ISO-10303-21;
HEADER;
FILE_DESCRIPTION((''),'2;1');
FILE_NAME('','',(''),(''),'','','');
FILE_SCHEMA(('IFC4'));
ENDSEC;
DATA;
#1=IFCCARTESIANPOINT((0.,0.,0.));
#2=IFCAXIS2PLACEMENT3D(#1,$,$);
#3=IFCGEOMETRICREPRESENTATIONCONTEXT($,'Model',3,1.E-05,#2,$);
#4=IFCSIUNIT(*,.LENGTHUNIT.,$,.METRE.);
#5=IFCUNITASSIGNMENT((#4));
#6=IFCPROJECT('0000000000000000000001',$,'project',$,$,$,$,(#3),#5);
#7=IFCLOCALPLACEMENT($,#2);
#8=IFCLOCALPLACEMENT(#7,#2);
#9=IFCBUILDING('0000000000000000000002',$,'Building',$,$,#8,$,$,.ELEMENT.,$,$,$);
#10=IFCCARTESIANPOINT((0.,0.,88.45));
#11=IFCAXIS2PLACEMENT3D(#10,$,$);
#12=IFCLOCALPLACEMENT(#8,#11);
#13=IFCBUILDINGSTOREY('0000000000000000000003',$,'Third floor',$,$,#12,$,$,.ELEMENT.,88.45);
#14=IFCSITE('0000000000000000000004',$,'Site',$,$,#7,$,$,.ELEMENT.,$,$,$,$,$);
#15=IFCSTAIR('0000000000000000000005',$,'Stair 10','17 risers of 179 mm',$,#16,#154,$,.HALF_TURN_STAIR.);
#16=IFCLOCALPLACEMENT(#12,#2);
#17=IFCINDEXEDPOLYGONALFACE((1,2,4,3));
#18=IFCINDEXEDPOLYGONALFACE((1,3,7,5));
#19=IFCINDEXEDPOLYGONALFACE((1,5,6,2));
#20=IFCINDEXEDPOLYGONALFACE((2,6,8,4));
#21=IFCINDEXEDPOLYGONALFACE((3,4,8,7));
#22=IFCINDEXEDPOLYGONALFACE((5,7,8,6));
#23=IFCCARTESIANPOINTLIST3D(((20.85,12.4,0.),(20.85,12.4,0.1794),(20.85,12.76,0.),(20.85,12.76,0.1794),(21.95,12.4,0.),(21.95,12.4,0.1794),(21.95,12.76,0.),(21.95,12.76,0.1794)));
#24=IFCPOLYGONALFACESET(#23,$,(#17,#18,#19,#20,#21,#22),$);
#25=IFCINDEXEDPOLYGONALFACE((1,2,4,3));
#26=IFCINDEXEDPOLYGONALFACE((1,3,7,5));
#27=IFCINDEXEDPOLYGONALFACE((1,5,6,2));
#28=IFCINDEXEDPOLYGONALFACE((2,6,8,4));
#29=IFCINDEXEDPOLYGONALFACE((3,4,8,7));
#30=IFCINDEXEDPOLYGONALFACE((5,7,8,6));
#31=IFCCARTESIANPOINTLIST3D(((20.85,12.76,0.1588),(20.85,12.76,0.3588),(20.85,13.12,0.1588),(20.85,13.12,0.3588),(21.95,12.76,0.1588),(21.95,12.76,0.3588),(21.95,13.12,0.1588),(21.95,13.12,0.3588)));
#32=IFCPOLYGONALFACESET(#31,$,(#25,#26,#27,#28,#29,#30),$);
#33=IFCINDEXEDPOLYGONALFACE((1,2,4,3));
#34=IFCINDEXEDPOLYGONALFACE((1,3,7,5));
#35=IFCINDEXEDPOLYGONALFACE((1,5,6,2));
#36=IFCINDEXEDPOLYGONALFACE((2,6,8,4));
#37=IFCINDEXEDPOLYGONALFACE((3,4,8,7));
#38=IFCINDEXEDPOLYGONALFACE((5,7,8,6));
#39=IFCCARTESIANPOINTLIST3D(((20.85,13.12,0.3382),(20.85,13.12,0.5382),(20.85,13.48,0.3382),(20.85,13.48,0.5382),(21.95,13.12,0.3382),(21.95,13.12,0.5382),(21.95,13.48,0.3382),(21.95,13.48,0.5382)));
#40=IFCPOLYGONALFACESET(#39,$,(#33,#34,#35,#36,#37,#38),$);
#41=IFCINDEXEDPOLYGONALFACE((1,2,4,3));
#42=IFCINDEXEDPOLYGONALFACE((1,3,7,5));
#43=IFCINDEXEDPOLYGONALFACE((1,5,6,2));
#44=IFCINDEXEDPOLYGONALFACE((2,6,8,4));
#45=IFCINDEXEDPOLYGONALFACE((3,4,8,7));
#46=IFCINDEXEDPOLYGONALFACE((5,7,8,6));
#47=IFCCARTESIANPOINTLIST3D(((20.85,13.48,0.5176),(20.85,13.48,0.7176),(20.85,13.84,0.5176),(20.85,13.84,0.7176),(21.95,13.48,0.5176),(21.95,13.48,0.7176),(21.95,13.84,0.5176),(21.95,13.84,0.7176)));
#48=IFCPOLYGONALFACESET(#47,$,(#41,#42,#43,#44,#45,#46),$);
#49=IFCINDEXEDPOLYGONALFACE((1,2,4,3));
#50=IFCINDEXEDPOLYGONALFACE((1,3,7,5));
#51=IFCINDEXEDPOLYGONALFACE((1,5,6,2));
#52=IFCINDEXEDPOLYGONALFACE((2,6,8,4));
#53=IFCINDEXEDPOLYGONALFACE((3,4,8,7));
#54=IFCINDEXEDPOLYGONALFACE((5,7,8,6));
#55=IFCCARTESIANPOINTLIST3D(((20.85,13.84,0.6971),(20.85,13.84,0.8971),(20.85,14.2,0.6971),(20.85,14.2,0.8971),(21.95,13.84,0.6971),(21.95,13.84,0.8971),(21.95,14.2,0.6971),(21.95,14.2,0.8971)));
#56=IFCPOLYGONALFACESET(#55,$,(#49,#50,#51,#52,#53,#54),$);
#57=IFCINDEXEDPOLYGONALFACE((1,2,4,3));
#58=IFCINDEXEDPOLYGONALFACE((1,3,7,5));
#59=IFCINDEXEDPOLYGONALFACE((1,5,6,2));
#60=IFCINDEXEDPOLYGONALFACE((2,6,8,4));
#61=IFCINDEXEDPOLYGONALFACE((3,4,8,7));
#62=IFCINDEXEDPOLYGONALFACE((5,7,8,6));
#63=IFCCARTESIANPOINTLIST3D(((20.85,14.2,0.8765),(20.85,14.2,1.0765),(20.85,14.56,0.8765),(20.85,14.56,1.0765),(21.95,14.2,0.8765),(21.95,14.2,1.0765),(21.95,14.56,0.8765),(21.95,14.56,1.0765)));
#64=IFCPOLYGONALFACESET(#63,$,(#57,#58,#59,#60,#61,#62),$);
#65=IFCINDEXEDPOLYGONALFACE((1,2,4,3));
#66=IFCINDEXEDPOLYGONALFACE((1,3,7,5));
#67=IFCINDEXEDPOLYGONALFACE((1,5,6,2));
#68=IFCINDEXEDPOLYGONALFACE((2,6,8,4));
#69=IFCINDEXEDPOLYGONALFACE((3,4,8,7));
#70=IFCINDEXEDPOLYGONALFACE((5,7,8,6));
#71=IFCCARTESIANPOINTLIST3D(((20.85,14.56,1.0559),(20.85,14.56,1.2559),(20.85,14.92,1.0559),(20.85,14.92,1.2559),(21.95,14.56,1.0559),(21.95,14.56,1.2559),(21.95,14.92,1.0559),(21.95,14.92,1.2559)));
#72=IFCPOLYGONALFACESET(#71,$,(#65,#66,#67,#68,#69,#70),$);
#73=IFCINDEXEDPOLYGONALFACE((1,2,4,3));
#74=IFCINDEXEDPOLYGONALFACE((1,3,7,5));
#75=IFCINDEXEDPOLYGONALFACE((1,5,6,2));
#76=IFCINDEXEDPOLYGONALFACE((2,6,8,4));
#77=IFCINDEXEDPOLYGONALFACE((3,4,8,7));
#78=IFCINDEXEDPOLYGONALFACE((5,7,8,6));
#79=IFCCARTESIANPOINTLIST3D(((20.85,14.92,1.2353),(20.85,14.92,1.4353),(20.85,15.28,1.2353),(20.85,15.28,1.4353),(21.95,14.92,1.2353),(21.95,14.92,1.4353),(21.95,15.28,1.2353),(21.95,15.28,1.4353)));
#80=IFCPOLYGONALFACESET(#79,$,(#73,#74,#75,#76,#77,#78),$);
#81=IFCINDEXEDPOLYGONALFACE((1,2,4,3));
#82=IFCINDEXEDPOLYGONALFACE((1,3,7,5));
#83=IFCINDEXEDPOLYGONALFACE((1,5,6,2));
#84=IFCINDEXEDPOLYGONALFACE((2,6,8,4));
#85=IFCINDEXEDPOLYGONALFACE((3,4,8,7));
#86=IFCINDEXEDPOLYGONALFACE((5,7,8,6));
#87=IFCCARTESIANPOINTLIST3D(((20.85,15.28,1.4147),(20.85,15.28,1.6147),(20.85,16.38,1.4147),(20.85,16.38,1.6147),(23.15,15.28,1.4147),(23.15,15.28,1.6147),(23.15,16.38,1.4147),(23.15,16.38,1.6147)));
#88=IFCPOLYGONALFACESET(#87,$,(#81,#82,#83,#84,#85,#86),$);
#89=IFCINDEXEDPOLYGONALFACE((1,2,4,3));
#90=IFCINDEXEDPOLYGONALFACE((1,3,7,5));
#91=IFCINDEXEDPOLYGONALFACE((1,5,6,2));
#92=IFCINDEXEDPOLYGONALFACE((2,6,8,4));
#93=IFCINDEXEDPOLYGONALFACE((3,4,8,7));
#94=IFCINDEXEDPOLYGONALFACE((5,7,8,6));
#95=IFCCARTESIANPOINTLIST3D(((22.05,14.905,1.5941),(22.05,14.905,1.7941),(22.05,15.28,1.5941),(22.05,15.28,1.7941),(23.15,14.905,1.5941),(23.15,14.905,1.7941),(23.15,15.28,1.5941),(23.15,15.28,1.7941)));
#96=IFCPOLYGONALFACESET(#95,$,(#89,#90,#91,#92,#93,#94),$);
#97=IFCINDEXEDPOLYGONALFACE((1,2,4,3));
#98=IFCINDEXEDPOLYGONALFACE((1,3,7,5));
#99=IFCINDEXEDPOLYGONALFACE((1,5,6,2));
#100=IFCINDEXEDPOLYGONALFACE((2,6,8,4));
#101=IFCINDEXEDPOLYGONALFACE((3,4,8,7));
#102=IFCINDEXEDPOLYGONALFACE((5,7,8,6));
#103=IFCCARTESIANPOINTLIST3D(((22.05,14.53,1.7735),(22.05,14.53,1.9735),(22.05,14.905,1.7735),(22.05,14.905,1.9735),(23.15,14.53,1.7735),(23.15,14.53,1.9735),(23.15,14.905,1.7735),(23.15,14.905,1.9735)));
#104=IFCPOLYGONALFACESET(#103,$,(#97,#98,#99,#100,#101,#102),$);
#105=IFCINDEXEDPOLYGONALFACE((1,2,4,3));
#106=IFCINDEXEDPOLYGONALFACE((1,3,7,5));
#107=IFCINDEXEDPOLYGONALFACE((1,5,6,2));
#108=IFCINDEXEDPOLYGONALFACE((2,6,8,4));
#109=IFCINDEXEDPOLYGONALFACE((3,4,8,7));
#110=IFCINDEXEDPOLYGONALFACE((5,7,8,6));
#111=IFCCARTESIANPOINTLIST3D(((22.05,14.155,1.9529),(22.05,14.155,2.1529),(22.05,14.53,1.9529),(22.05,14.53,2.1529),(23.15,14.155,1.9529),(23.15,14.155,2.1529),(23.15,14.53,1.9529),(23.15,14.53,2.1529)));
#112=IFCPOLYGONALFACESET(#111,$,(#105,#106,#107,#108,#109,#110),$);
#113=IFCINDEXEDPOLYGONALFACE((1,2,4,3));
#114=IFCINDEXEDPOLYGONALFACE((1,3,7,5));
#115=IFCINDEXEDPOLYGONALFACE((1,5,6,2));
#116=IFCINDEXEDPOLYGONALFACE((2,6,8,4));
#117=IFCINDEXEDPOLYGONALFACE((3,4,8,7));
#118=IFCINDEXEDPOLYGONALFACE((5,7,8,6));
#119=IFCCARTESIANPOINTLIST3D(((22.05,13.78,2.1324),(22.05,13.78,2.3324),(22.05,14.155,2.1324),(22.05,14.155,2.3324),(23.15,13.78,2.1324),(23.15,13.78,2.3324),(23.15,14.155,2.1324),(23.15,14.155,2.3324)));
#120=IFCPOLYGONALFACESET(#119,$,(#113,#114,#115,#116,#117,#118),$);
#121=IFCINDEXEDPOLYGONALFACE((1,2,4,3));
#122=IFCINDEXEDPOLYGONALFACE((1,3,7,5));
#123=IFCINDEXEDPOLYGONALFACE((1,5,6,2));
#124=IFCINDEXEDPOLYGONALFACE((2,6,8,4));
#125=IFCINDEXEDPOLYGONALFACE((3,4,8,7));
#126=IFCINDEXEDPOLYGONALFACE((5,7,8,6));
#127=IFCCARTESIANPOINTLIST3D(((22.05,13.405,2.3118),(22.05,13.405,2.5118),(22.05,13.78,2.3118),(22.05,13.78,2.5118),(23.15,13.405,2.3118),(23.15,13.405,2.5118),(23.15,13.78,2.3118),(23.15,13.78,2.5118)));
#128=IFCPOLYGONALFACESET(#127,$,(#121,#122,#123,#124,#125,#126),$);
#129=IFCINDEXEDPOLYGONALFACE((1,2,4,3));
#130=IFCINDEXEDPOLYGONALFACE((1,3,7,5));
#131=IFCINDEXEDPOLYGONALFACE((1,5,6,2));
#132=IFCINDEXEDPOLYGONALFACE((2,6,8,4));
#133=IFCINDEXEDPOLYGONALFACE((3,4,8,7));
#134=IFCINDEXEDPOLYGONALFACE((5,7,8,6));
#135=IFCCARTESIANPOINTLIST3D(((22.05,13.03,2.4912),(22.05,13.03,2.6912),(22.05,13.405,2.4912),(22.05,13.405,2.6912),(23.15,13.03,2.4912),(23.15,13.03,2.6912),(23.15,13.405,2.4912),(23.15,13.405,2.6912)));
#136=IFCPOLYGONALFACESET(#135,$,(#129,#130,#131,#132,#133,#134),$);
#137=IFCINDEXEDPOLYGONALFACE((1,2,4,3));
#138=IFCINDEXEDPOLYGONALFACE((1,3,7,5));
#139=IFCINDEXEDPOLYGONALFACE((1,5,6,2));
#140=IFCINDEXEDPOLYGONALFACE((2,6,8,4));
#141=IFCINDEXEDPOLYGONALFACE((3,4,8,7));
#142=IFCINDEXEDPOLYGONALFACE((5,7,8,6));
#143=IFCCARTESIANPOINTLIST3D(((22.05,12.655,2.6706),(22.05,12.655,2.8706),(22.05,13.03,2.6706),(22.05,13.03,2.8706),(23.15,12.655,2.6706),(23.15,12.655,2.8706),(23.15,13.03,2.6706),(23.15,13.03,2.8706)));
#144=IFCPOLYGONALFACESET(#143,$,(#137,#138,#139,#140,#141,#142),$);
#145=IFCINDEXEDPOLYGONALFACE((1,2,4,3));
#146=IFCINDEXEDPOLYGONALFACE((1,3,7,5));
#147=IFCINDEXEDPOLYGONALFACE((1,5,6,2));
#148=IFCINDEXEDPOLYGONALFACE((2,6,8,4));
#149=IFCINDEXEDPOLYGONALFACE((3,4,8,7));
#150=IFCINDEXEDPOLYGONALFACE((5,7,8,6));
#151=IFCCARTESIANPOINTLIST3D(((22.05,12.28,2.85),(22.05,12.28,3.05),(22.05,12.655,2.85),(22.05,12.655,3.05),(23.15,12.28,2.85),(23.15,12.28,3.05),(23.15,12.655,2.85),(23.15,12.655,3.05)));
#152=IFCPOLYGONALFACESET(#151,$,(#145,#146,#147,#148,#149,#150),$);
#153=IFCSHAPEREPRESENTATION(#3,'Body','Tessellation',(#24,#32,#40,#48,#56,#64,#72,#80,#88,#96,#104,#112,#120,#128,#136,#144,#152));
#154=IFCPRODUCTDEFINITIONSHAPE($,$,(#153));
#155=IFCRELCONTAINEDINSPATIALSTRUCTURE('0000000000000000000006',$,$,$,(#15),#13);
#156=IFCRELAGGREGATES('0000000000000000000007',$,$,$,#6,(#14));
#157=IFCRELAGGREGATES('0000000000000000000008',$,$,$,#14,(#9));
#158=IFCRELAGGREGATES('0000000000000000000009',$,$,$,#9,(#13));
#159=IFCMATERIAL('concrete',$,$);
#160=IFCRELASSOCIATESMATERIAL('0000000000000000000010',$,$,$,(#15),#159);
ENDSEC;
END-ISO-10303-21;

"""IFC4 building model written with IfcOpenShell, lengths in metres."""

from ifc_helpers import new_model, si_unit, frame, origin, place, context, project, spatial, polyline, outline, extrude, material, element, save


model = new_model("IFC4")

# Units and contexts
model_context = context("Model", 3, precision=1e-05, world=origin())
ifc_project = project(units=[si_unit("LENGTHUNIT", "METRE")], contexts=[model_context])

# Site, building, storey
site_placement = place(None, origin())
site = spatial("IfcSite", under=ifc_project, at=site_placement, Name="Site", CompositionType="ELEMENT")
building_placement = place(site_placement, origin())
building = spatial("IfcBuilding", under=site, at=building_placement, Name="Building", CompositionType="ELEMENT")
storey_placement = place(building_placement, frame((0.0, 0.0, 88.45)))
storey = spatial("IfcBuildingStorey", under=building, at=storey_placement, Name="Third floor", CompositionType="ELEMENT", Elevation=88.45)

# Shared definitions
ifc_material = material(Name="concrete")

# Stair
stair_1_placement = place(storey_placement, frame((21.4, 12.4, 0.0), z_axis=(0.0, 0.0, 1.0), x_axis=(0.0, 1.0, 0.0)))
element("IfcStair", 1, at=stair_1_placement, inside=storey, material=ifc_material, Name="Stair 10", Description="17 risers of 179 mm", PredefinedType="HALF_TURN_STAIR", context=model_context, shape_type="SweptSolid", body=[
    extrude(outline(polyline([(0.0, -0.55), (0.36, -0.55), (0.36, 0.55), (0.0, 0.55), (0.0, -0.55)])), origin(), (0.0, 0.0, 1.0), 0.1794),
    extrude(outline(polyline([(0.36, -0.55), (0.72, -0.55), (0.72, 0.55), (0.36, 0.55), (0.36, -0.55)])), frame((0.0, 0.0, 0.1588)), (0.0, 0.0, 1.0), 0.2),
    extrude(outline(polyline([(0.72, -0.55), (1.08, -0.55), (1.08, 0.55), (0.72, 0.55), (0.72, -0.55)])), frame((0.0, 0.0, 0.3382)), (0.0, 0.0, 1.0), 0.2),
    extrude(outline(polyline([(1.08, -0.55), (1.44, -0.55), (1.44, 0.55), (1.08, 0.55), (1.08, -0.55)])), frame((0.0, 0.0, 0.5176)), (0.0, 0.0, 1.0), 0.2),
    extrude(outline(polyline([(1.44, -0.55), (1.8, -0.55), (1.8, 0.55), (1.44, 0.55), (1.44, -0.55)])), frame((0.0, 0.0, 0.6971)), (0.0, 0.0, 1.0), 0.2),
    extrude(outline(polyline([(1.8, -0.55), (2.16, -0.55), (2.16, 0.55), (1.8, 0.55), (1.8, -0.55)])), frame((0.0, 0.0, 0.8765)), (0.0, 0.0, 1.0), 0.2),
    extrude(outline(polyline([(2.16, -0.55), (2.52, -0.55), (2.52, 0.55), (2.16, 0.55), (2.16, -0.55)])), frame((0.0, 0.0, 1.0559)), (0.0, 0.0, 1.0), 0.2),
    extrude(outline(polyline([(2.52, -0.55), (2.88, -0.55), (2.88, 0.55), (2.52, 0.55), (2.52, -0.55)])), frame((0.0, 0.0, 1.2353)), (0.0, 0.0, 1.0), 0.2),
    extrude(outline(polyline([(2.88, -1.75), (3.98, -1.75), (3.98, 0.55), (2.88, 0.55), (2.88, -1.75)])), frame((0.0, 0.0, 1.4147)), (0.0, 0.0, 1.0), 0.2),
    extrude(outline(polyline([(2.505, -1.75), (2.88, -1.75), (2.88, -0.65), (2.505, -0.65), (2.505, -1.75)])), frame((0.0, 0.0, 1.5941)), (0.0, 0.0, 1.0), 0.2),
    extrude(outline(polyline([(2.13, -1.75), (2.505, -1.75), (2.505, -0.65), (2.13, -0.65), (2.13, -1.75)])), frame((0.0, 0.0, 1.7735)), (0.0, 0.0, 1.0), 0.2),
    extrude(outline(polyline([(1.755, -1.75), (2.13, -1.75), (2.13, -0.65), (1.755, -0.65), (1.755, -1.75)])), frame((0.0, 0.0, 1.9529)), (0.0, 0.0, 1.0), 0.2),
    extrude(outline(polyline([(1.38, -1.75), (1.755, -1.75), (1.755, -0.65), (1.38, -0.65), (1.38, -1.75)])), frame((0.0, 0.0, 2.1324)), (0.0, 0.0, 1.0), 0.2),
    extrude(outline(polyline([(1.005, -1.75), (1.38, -1.75), (1.38, -0.65), (1.005, -0.65), (1.005, -1.75)])), frame((0.0, 0.0, 2.3118)), (0.0, 0.0, 1.0), 0.2),
    extrude(outline(polyline([(0.63, -1.75), (1.005, -1.75), (1.005, -0.65), (0.63, -0.65), (0.63, -1.75)])), frame((0.0, 0.0, 2.4912)), (0.0, 0.0, 1.0), 0.2),
    extrude(outline(polyline([(0.255, -1.75), (0.63, -1.75), (0.63, -0.65), (0.255, -0.65), (0.255, -1.75)])), frame((0.0, 0.0, 2.6706)), (0.0, 0.0, 1.0), 0.2),
    extrude(outline(polyline([(-0.12, -1.75), (0.255, -1.75), (0.255, -0.65), (-0.12, -0.65), (-0.12, -1.75)])), frame((0.0, 0.0, 2.85)), (0.0, 0.0, 1.0), 0.2),
])

save(model, "model.ifc")
